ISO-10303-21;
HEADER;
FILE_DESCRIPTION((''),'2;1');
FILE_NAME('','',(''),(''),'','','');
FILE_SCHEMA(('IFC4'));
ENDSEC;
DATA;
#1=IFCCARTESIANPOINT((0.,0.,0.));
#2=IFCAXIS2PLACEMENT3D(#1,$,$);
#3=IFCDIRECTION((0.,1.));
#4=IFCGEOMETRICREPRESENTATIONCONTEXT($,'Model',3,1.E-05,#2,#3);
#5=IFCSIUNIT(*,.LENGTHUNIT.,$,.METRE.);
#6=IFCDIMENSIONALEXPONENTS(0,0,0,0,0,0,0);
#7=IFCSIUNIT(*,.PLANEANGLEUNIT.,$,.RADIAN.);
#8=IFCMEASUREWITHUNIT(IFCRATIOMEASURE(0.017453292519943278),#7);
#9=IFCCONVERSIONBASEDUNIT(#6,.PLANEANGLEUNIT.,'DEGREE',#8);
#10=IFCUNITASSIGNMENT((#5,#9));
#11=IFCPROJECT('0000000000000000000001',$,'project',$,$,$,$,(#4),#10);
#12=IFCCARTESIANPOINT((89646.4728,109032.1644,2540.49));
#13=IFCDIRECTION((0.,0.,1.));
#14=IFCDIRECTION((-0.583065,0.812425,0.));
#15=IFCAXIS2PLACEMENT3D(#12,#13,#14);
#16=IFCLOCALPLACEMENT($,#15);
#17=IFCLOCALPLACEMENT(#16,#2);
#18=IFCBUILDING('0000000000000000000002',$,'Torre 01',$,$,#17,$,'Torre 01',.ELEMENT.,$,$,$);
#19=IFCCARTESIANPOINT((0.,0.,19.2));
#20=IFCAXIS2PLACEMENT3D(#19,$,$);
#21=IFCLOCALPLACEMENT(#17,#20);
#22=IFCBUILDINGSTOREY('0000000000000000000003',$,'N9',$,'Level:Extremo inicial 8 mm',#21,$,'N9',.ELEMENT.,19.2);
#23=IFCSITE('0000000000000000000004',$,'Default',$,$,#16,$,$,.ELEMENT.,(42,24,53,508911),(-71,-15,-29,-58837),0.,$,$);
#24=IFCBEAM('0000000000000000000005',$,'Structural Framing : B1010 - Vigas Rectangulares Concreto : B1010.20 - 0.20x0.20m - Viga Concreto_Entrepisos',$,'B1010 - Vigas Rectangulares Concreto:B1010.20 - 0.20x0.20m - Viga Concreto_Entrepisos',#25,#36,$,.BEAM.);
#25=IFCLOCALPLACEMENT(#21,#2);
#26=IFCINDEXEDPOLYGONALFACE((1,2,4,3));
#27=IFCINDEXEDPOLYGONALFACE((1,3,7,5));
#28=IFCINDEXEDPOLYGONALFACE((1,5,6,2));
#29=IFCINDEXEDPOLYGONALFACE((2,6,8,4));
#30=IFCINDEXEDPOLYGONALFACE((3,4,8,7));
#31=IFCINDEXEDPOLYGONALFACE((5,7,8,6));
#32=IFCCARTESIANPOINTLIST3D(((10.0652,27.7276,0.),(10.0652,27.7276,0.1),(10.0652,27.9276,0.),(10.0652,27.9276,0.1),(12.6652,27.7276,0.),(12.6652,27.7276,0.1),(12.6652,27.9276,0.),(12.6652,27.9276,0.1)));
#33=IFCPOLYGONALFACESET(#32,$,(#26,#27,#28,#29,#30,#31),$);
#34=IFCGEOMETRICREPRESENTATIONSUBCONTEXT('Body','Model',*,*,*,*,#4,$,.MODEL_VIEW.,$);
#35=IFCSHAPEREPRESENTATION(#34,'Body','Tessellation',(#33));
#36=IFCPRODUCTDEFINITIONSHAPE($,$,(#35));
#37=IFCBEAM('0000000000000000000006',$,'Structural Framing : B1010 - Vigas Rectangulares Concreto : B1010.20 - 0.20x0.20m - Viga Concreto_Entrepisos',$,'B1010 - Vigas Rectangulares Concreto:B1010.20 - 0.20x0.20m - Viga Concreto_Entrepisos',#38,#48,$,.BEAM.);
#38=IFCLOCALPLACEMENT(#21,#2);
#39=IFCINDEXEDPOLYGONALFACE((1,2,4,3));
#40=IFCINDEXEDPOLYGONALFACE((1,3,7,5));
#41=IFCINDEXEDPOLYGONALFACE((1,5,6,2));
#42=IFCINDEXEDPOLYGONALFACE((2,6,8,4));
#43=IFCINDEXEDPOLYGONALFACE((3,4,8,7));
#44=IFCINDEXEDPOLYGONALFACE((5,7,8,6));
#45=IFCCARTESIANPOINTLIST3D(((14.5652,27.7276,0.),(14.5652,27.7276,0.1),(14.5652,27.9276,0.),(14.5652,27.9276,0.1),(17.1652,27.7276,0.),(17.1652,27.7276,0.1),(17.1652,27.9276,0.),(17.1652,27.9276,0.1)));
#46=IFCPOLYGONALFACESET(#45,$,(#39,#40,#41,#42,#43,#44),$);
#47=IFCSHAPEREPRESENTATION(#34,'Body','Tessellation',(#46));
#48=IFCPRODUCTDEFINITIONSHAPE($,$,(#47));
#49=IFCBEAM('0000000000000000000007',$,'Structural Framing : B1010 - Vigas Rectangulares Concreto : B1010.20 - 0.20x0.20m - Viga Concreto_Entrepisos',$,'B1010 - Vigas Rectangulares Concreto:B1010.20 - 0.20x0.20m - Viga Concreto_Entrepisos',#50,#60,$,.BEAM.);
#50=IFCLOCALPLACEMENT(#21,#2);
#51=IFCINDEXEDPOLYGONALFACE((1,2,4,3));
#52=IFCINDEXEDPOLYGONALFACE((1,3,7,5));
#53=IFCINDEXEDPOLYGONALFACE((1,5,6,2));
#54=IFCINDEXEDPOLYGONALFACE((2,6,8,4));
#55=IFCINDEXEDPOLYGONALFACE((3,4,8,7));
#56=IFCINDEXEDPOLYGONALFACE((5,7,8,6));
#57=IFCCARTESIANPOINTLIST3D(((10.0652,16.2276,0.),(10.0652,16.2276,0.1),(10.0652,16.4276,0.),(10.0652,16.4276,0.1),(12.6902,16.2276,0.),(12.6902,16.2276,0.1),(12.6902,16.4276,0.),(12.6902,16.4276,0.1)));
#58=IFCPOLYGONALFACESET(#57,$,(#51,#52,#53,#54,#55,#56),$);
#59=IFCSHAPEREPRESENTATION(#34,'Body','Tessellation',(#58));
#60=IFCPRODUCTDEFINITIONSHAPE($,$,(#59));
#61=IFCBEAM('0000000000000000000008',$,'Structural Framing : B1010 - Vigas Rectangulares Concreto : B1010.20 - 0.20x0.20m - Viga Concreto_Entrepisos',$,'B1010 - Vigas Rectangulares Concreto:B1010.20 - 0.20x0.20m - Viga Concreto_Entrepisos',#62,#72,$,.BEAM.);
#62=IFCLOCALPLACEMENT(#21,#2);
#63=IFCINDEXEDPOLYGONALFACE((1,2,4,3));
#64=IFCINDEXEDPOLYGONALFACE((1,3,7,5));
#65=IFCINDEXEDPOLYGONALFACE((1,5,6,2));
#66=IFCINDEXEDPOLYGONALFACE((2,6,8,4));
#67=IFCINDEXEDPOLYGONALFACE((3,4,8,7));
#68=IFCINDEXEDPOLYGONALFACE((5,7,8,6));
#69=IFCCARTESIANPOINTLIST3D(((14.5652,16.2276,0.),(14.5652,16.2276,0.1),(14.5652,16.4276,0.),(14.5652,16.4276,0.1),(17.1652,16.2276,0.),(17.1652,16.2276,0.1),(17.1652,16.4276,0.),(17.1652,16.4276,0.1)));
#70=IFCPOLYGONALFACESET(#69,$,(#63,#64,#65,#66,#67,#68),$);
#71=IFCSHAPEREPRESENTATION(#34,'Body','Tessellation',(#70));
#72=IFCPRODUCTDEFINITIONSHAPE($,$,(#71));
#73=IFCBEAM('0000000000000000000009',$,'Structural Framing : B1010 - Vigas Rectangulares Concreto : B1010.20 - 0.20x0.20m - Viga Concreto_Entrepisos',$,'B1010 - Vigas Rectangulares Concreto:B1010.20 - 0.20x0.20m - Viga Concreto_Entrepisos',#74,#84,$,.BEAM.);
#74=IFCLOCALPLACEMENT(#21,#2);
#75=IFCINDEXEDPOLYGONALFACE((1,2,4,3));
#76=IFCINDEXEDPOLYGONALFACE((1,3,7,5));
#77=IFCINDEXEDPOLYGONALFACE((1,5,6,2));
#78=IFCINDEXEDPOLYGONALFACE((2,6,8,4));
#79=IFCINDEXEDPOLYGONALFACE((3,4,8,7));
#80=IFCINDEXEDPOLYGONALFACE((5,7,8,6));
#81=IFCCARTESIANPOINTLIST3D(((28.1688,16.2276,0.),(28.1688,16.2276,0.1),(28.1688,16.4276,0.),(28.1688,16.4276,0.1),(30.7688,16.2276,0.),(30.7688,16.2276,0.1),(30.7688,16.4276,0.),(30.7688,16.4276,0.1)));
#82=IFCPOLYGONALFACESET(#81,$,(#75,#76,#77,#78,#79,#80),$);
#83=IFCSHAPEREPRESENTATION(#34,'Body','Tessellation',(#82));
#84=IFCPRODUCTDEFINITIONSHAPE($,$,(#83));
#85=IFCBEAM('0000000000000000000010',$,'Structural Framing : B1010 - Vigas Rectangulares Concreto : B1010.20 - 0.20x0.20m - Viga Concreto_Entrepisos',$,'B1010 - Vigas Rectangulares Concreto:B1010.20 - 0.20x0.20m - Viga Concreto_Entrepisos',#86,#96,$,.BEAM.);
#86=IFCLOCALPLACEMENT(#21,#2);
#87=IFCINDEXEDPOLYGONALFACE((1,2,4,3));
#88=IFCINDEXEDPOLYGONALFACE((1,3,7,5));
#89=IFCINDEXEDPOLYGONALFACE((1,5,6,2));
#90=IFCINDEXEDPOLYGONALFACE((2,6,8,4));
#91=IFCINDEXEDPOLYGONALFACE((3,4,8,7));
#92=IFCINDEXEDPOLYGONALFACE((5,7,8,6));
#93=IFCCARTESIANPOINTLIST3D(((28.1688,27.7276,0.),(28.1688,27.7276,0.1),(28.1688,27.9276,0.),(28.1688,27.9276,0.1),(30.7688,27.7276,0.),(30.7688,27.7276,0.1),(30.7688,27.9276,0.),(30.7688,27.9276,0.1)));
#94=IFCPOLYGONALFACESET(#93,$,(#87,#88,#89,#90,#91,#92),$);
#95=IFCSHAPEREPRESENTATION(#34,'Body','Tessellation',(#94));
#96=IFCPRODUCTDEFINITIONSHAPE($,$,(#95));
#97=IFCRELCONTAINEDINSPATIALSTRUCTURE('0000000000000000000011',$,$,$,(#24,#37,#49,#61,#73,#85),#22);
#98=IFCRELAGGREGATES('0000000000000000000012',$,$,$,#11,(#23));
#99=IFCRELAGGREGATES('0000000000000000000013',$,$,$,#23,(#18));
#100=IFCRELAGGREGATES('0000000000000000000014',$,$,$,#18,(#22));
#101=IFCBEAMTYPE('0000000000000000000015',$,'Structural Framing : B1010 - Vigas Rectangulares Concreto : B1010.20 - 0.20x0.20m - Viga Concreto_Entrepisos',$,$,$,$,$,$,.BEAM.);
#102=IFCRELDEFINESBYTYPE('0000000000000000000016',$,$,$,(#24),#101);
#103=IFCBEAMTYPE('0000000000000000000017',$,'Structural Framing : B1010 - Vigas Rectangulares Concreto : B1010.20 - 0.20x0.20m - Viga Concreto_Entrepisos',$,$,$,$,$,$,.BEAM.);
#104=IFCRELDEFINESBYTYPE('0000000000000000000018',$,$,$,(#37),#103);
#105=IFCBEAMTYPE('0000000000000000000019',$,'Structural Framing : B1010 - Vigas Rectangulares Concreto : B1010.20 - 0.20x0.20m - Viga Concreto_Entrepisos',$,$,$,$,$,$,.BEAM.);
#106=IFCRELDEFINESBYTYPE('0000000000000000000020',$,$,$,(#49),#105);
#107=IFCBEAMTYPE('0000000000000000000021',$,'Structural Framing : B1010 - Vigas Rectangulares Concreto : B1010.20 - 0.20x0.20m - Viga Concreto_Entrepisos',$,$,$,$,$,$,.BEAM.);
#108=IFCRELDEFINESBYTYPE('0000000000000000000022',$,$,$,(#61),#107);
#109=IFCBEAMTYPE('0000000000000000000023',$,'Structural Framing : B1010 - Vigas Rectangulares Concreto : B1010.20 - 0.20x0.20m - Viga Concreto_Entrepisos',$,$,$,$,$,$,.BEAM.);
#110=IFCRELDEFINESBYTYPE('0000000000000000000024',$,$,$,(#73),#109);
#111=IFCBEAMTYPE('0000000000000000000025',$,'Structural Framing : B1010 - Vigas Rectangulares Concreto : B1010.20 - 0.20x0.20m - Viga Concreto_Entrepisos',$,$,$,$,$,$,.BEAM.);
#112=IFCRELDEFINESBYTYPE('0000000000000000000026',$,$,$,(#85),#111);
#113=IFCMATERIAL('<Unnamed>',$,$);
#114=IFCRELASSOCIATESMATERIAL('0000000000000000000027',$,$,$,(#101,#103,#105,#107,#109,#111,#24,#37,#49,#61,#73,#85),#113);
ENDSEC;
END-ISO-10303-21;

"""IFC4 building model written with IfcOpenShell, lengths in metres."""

from ifc_helpers import new_model, entity, si_unit, converted_unit, direction, frame, frame_2d, origin, place, context, subcontext, project, spatial, polyline, segment, composite_curve, rectangle, outline, extrude, source, transform, mapped, material, material_profile, profile_set, profile_usage, type_object, type_shapes, element, save


model = new_model("IFC4")

# Units and contexts
model_context = context("Model", 3, precision=1e-05, world=origin(), true_north=direction((0.0, 1.0)))
body_context = subcontext(model_context, "Body", "Model", "MODEL_VIEW")
ifc_project = project(units=[si_unit("LENGTHUNIT", "METRE"), converted_unit("PLANEANGLEUNIT", "DEGREE", entity("IfcRatioMeasure", 0.017453292519943278), si_unit("PLANEANGLEUNIT", "RADIAN"), dimensions=[0, 0, 0, 0, 0, 0, 0])], contexts=[model_context])

# Site, building, storey
site_placement = place(None, frame((89646.4728, 109032.1644, 2540.49), z_axis=(0.0, 0.0, 1.0), x_axis=(-0.583065, 0.812425, 0.0)))
site = spatial("IfcSite", under=ifc_project, at=site_placement, Name="Default", CompositionType="ELEMENT", RefLatitude=(42, 24, 53, 508911), RefLongitude=(-71, -15, -29, -58837), RefElevation=0.0)
building_placement = place(site_placement, origin())
building = spatial("IfcBuilding", under=site, at=building_placement, Name="Torre 01", LongName="Torre 01", CompositionType="ELEMENT")
storey_placement = place(building_placement, frame((0.0, 0.0, 19.2)))
storey = spatial("IfcBuildingStorey", under=building, at=storey_placement, Name="N9", ObjectType="Level:Extremo inicial 8 mm", LongName="N9", CompositionType="ELEMENT", Elevation=19.2)

# Beams
ifc_material = material(Name="<Unnamed>")
ifc_material_profile_1 = material_profile(ifc_material, outline(composite_curve([segment(polyline([(-0.1, 0.0, 0.0), (-0.1, 0.1, 0.0)]), True, "CONTINUOUS"), segment(polyline([(-0.1, 0.1, 0.0), (0.1, 0.1, 0.0)]), True, "CONTINUOUS"), segment(polyline([(0.1, 0.1, 0.0), (0.1, 0.0, 0.0)]), True, "CONTINUOUS"), segment(polyline([(0.1, 0.0, 0.0), (-0.1, 0.0, 0.0)]), True, "CONTINUOUS")], self_intersect=False), kind="CURVE"), Name="B1010.20 - 0.20x0.20m - Viga Concreto_Entrepisos")
ifc_material_profile_2 = material_profile(ifc_material, outline(composite_curve([segment(polyline([(-1.3, -0.1, 0.1), (-1.3, 0.1, 0.1)]), True, "CONTINUOUS"), segment(polyline([(-1.3, 0.1, 0.1), (-1.3, 0.1, -0.1)]), True, "CONTINUOUS"), segment(polyline([(-1.3, 0.1, -0.1), (-1.3, -0.1, -0.1)]), True, "CONTINUOUS"), segment(polyline([(-1.3, -0.1, -0.1), (-1.3, -0.1, 0.1)]), True, "CONTINUOUS")], self_intersect=False), kind="CURVE"), Name="B1010.20 - 0.20x0.20m - Viga Concreto_Entrepisos")
ifc_profile_set = profile_set([ifc_material_profile_1, ifc_material_profile_2], Name="B1010.20 - 0.20x0.20m - Viga Concreto_Entrepisos")
ifc_profile_usage_1 = profile_usage(ifc_profile_set, cardinal=8)
beam_type_1 = type_object("IfcBeamType", Name="Structural Framing : B1010 - Vigas Rectangulares Concreto : B1010.20 - 0.20x0.20m - Viga Concreto_Entrepisos", PredefinedType="BEAM", material=ifc_profile_set)
shared_shape_1 = source(origin(), body_context, "Body", "SweptSolid", [
    extrude(rectangle(XDim=0.1, YDim=0.2, at=frame_2d((0.0, 0.0), x_axis=(1.0, 0.0))), frame((10.0652, 27.8276, 19.25), z_axis=(1.0, 0.0, 0.0), x_axis=(0.0, 0.0, -1.0)), (0.0, 0.0, 1.0), 2.6),
])
type_shapes(beam_type_1, [shared_shape_1])
beam_1_placement = place(storey_placement, frame((0.0, 0.0, -19.2)))
element("IfcBeam", 1, at=beam_1_placement, inside=storey, type_object=beam_type_1, material=ifc_profile_usage_1, Name="Structural Framing : B1010 - Vigas Rectangulares Concreto : B1010.20 - 0.20x0.20m - Viga Concreto_Entrepisos", ObjectType="B1010 - Vigas Rectangulares Concreto:B1010.20 - 0.20x0.20m - Viga Concreto_Entrepisos", PredefinedType="BEAM", context=body_context, shape_type="MappedRepresentation", body=[
    mapped(shared_shape_1, transform((0.0, 0.0, 0.0), scale=1.0)),
])
ifc_profile_usage_2 = profile_usage(ifc_profile_set, cardinal=8)
beam_type_2 = type_object("IfcBeamType", Name="Structural Framing : B1010 - Vigas Rectangulares Concreto : B1010.20 - 0.20x0.20m - Viga Concreto_Entrepisos", PredefinedType="BEAM", material=ifc_profile_set)
shared_shape_2 = source(origin(), body_context, "Body", "SweptSolid", [
    extrude(rectangle(XDim=0.1, YDim=0.2, at=frame_2d((0.0, 0.0), x_axis=(1.0, 0.0))), frame((17.1652, 27.8276, 19.25), z_axis=(-1.0, 0.0, 0.0), x_axis=(0.0, 0.0, -1.0)), (0.0, 0.0, 1.0), 2.6),
])
type_shapes(beam_type_2, [shared_shape_2])
beam_2_placement = place(storey_placement, frame((0.0, 0.0, -19.2)))
element("IfcBeam", 2, at=beam_2_placement, inside=storey, type_object=beam_type_2, material=ifc_profile_usage_2, Name="Structural Framing : B1010 - Vigas Rectangulares Concreto : B1010.20 - 0.20x0.20m - Viga Concreto_Entrepisos", ObjectType="B1010 - Vigas Rectangulares Concreto:B1010.20 - 0.20x0.20m - Viga Concreto_Entrepisos", PredefinedType="BEAM", context=body_context, shape_type="MappedRepresentation", body=[
    mapped(shared_shape_2, transform((0.0, 0.0, 0.0), scale=1.0)),
])
ifc_profile_usage_3 = profile_usage(ifc_profile_set, cardinal=8)
beam_type_3 = type_object("IfcBeamType", Name="Structural Framing : B1010 - Vigas Rectangulares Concreto : B1010.20 - 0.20x0.20m - Viga Concreto_Entrepisos", PredefinedType="BEAM", material=ifc_profile_set)
shared_shape_3 = source(origin(), body_context, "Body", "SweptSolid", [
    extrude(rectangle(XDim=0.1, YDim=0.2, at=frame_2d((0.0, 0.0), x_axis=(1.0, 0.0))), frame((10.0652, 16.3276, 19.25), z_axis=(1.0, 0.0, 0.0), x_axis=(0.0, 0.0, -1.0)), (0.0, 0.0, 1.0), 2.625),
])
type_shapes(beam_type_3, [shared_shape_3])
beam_3_placement = place(storey_placement, frame((0.0, 0.0, -19.2)))
element("IfcBeam", 3, at=beam_3_placement, inside=storey, type_object=beam_type_3, material=ifc_profile_usage_3, Name="Structural Framing : B1010 - Vigas Rectangulares Concreto : B1010.20 - 0.20x0.20m - Viga Concreto_Entrepisos", ObjectType="B1010 - Vigas Rectangulares Concreto:B1010.20 - 0.20x0.20m - Viga Concreto_Entrepisos", PredefinedType="BEAM", context=body_context, shape_type="MappedRepresentation", body=[
    mapped(shared_shape_3, transform((0.0, 0.0, 0.0), scale=1.0)),
])
ifc_profile_usage_4 = profile_usage(ifc_profile_set, cardinal=8)
beam_type_4 = type_object("IfcBeamType", Name="Structural Framing : B1010 - Vigas Rectangulares Concreto : B1010.20 - 0.20x0.20m - Viga Concreto_Entrepisos", PredefinedType="BEAM", material=ifc_profile_set)
shared_shape_4 = source(origin(), body_context, "Body", "SweptSolid", [
    extrude(rectangle(XDim=0.1, YDim=0.2, at=frame_2d((0.0, 0.0), x_axis=(1.0, 0.0))), frame((17.1652, 16.3276, 19.25), z_axis=(-1.0, 0.0, 0.0), x_axis=(0.0, 0.0, -1.0)), (0.0, 0.0, 1.0), 2.6),
])
type_shapes(beam_type_4, [shared_shape_4])
beam_4_placement = place(storey_placement, frame((0.0, 0.0, -19.2)))
element("IfcBeam", 4, at=beam_4_placement, inside=storey, type_object=beam_type_4, material=ifc_profile_usage_4, Name="Structural Framing : B1010 - Vigas Rectangulares Concreto : B1010.20 - 0.20x0.20m - Viga Concreto_Entrepisos", ObjectType="B1010 - Vigas Rectangulares Concreto:B1010.20 - 0.20x0.20m - Viga Concreto_Entrepisos", PredefinedType="BEAM", context=body_context, shape_type="MappedRepresentation", body=[
    mapped(shared_shape_4, transform((0.0, 0.0, 0.0), scale=1.0)),
])
ifc_profile_usage_5 = profile_usage(ifc_profile_set, cardinal=8)
beam_type_5 = type_object("IfcBeamType", Name="Structural Framing : B1010 - Vigas Rectangulares Concreto : B1010.20 - 0.20x0.20m - Viga Concreto_Entrepisos", PredefinedType="BEAM", material=ifc_profile_set)
shared_shape_5 = source(origin(), body_context, "Body", "SweptSolid", [
    extrude(rectangle(XDim=0.1, YDim=0.2, at=frame_2d((0.0, 0.0), x_axis=(1.0, 0.0))), frame((28.1688, 16.3276, 19.25), z_axis=(1.0, 0.0, 0.0), x_axis=(0.0, 0.0, -1.0)), (0.0, 0.0, 1.0), 2.6),
])
type_shapes(beam_type_5, [shared_shape_5])
beam_5_placement = place(storey_placement, frame((0.0, 0.0, -19.2)))
element("IfcBeam", 5, at=beam_5_placement, inside=storey, type_object=beam_type_5, material=ifc_profile_usage_5, Name="Structural Framing : B1010 - Vigas Rectangulares Concreto : B1010.20 - 0.20x0.20m - Viga Concreto_Entrepisos", ObjectType="B1010 - Vigas Rectangulares Concreto:B1010.20 - 0.20x0.20m - Viga Concreto_Entrepisos", PredefinedType="BEAM", context=body_context, shape_type="MappedRepresentation", body=[
    mapped(shared_shape_5, transform((0.0, 0.0, 0.0), scale=1.0)),
])
ifc_profile_usage_6 = profile_usage(ifc_profile_set, cardinal=8)
beam_type_6 = type_object("IfcBeamType", Name="Structural Framing : B1010 - Vigas Rectangulares Concreto : B1010.20 - 0.20x0.20m - Viga Concreto_Entrepisos", PredefinedType="BEAM", material=ifc_profile_set)
shared_shape_6 = source(origin(), body_context, "Body", "SweptSolid", [
    extrude(rectangle(XDim=0.1, YDim=0.2, at=frame_2d((0.0, 0.0), x_axis=(1.0, 0.0))), frame((28.1688, 27.8276, 19.25), z_axis=(1.0, 0.0, 0.0), x_axis=(0.0, 0.0, -1.0)), (0.0, 0.0, 1.0), 2.6),
])
type_shapes(beam_type_6, [shared_shape_6])
beam_6_placement = place(storey_placement, frame((0.0, 0.0, -19.2)))
element("IfcBeam", 6, at=beam_6_placement, inside=storey, type_object=beam_type_6, material=ifc_profile_usage_6, Name="Structural Framing : B1010 - Vigas Rectangulares Concreto : B1010.20 - 0.20x0.20m - Viga Concreto_Entrepisos", ObjectType="B1010 - Vigas Rectangulares Concreto:B1010.20 - 0.20x0.20m - Viga Concreto_Entrepisos", PredefinedType="BEAM", context=body_context, shape_type="MappedRepresentation", body=[
    mapped(shared_shape_6, transform((0.0, 0.0, 0.0), scale=1.0)),
])

save(model, "model.ifc")
